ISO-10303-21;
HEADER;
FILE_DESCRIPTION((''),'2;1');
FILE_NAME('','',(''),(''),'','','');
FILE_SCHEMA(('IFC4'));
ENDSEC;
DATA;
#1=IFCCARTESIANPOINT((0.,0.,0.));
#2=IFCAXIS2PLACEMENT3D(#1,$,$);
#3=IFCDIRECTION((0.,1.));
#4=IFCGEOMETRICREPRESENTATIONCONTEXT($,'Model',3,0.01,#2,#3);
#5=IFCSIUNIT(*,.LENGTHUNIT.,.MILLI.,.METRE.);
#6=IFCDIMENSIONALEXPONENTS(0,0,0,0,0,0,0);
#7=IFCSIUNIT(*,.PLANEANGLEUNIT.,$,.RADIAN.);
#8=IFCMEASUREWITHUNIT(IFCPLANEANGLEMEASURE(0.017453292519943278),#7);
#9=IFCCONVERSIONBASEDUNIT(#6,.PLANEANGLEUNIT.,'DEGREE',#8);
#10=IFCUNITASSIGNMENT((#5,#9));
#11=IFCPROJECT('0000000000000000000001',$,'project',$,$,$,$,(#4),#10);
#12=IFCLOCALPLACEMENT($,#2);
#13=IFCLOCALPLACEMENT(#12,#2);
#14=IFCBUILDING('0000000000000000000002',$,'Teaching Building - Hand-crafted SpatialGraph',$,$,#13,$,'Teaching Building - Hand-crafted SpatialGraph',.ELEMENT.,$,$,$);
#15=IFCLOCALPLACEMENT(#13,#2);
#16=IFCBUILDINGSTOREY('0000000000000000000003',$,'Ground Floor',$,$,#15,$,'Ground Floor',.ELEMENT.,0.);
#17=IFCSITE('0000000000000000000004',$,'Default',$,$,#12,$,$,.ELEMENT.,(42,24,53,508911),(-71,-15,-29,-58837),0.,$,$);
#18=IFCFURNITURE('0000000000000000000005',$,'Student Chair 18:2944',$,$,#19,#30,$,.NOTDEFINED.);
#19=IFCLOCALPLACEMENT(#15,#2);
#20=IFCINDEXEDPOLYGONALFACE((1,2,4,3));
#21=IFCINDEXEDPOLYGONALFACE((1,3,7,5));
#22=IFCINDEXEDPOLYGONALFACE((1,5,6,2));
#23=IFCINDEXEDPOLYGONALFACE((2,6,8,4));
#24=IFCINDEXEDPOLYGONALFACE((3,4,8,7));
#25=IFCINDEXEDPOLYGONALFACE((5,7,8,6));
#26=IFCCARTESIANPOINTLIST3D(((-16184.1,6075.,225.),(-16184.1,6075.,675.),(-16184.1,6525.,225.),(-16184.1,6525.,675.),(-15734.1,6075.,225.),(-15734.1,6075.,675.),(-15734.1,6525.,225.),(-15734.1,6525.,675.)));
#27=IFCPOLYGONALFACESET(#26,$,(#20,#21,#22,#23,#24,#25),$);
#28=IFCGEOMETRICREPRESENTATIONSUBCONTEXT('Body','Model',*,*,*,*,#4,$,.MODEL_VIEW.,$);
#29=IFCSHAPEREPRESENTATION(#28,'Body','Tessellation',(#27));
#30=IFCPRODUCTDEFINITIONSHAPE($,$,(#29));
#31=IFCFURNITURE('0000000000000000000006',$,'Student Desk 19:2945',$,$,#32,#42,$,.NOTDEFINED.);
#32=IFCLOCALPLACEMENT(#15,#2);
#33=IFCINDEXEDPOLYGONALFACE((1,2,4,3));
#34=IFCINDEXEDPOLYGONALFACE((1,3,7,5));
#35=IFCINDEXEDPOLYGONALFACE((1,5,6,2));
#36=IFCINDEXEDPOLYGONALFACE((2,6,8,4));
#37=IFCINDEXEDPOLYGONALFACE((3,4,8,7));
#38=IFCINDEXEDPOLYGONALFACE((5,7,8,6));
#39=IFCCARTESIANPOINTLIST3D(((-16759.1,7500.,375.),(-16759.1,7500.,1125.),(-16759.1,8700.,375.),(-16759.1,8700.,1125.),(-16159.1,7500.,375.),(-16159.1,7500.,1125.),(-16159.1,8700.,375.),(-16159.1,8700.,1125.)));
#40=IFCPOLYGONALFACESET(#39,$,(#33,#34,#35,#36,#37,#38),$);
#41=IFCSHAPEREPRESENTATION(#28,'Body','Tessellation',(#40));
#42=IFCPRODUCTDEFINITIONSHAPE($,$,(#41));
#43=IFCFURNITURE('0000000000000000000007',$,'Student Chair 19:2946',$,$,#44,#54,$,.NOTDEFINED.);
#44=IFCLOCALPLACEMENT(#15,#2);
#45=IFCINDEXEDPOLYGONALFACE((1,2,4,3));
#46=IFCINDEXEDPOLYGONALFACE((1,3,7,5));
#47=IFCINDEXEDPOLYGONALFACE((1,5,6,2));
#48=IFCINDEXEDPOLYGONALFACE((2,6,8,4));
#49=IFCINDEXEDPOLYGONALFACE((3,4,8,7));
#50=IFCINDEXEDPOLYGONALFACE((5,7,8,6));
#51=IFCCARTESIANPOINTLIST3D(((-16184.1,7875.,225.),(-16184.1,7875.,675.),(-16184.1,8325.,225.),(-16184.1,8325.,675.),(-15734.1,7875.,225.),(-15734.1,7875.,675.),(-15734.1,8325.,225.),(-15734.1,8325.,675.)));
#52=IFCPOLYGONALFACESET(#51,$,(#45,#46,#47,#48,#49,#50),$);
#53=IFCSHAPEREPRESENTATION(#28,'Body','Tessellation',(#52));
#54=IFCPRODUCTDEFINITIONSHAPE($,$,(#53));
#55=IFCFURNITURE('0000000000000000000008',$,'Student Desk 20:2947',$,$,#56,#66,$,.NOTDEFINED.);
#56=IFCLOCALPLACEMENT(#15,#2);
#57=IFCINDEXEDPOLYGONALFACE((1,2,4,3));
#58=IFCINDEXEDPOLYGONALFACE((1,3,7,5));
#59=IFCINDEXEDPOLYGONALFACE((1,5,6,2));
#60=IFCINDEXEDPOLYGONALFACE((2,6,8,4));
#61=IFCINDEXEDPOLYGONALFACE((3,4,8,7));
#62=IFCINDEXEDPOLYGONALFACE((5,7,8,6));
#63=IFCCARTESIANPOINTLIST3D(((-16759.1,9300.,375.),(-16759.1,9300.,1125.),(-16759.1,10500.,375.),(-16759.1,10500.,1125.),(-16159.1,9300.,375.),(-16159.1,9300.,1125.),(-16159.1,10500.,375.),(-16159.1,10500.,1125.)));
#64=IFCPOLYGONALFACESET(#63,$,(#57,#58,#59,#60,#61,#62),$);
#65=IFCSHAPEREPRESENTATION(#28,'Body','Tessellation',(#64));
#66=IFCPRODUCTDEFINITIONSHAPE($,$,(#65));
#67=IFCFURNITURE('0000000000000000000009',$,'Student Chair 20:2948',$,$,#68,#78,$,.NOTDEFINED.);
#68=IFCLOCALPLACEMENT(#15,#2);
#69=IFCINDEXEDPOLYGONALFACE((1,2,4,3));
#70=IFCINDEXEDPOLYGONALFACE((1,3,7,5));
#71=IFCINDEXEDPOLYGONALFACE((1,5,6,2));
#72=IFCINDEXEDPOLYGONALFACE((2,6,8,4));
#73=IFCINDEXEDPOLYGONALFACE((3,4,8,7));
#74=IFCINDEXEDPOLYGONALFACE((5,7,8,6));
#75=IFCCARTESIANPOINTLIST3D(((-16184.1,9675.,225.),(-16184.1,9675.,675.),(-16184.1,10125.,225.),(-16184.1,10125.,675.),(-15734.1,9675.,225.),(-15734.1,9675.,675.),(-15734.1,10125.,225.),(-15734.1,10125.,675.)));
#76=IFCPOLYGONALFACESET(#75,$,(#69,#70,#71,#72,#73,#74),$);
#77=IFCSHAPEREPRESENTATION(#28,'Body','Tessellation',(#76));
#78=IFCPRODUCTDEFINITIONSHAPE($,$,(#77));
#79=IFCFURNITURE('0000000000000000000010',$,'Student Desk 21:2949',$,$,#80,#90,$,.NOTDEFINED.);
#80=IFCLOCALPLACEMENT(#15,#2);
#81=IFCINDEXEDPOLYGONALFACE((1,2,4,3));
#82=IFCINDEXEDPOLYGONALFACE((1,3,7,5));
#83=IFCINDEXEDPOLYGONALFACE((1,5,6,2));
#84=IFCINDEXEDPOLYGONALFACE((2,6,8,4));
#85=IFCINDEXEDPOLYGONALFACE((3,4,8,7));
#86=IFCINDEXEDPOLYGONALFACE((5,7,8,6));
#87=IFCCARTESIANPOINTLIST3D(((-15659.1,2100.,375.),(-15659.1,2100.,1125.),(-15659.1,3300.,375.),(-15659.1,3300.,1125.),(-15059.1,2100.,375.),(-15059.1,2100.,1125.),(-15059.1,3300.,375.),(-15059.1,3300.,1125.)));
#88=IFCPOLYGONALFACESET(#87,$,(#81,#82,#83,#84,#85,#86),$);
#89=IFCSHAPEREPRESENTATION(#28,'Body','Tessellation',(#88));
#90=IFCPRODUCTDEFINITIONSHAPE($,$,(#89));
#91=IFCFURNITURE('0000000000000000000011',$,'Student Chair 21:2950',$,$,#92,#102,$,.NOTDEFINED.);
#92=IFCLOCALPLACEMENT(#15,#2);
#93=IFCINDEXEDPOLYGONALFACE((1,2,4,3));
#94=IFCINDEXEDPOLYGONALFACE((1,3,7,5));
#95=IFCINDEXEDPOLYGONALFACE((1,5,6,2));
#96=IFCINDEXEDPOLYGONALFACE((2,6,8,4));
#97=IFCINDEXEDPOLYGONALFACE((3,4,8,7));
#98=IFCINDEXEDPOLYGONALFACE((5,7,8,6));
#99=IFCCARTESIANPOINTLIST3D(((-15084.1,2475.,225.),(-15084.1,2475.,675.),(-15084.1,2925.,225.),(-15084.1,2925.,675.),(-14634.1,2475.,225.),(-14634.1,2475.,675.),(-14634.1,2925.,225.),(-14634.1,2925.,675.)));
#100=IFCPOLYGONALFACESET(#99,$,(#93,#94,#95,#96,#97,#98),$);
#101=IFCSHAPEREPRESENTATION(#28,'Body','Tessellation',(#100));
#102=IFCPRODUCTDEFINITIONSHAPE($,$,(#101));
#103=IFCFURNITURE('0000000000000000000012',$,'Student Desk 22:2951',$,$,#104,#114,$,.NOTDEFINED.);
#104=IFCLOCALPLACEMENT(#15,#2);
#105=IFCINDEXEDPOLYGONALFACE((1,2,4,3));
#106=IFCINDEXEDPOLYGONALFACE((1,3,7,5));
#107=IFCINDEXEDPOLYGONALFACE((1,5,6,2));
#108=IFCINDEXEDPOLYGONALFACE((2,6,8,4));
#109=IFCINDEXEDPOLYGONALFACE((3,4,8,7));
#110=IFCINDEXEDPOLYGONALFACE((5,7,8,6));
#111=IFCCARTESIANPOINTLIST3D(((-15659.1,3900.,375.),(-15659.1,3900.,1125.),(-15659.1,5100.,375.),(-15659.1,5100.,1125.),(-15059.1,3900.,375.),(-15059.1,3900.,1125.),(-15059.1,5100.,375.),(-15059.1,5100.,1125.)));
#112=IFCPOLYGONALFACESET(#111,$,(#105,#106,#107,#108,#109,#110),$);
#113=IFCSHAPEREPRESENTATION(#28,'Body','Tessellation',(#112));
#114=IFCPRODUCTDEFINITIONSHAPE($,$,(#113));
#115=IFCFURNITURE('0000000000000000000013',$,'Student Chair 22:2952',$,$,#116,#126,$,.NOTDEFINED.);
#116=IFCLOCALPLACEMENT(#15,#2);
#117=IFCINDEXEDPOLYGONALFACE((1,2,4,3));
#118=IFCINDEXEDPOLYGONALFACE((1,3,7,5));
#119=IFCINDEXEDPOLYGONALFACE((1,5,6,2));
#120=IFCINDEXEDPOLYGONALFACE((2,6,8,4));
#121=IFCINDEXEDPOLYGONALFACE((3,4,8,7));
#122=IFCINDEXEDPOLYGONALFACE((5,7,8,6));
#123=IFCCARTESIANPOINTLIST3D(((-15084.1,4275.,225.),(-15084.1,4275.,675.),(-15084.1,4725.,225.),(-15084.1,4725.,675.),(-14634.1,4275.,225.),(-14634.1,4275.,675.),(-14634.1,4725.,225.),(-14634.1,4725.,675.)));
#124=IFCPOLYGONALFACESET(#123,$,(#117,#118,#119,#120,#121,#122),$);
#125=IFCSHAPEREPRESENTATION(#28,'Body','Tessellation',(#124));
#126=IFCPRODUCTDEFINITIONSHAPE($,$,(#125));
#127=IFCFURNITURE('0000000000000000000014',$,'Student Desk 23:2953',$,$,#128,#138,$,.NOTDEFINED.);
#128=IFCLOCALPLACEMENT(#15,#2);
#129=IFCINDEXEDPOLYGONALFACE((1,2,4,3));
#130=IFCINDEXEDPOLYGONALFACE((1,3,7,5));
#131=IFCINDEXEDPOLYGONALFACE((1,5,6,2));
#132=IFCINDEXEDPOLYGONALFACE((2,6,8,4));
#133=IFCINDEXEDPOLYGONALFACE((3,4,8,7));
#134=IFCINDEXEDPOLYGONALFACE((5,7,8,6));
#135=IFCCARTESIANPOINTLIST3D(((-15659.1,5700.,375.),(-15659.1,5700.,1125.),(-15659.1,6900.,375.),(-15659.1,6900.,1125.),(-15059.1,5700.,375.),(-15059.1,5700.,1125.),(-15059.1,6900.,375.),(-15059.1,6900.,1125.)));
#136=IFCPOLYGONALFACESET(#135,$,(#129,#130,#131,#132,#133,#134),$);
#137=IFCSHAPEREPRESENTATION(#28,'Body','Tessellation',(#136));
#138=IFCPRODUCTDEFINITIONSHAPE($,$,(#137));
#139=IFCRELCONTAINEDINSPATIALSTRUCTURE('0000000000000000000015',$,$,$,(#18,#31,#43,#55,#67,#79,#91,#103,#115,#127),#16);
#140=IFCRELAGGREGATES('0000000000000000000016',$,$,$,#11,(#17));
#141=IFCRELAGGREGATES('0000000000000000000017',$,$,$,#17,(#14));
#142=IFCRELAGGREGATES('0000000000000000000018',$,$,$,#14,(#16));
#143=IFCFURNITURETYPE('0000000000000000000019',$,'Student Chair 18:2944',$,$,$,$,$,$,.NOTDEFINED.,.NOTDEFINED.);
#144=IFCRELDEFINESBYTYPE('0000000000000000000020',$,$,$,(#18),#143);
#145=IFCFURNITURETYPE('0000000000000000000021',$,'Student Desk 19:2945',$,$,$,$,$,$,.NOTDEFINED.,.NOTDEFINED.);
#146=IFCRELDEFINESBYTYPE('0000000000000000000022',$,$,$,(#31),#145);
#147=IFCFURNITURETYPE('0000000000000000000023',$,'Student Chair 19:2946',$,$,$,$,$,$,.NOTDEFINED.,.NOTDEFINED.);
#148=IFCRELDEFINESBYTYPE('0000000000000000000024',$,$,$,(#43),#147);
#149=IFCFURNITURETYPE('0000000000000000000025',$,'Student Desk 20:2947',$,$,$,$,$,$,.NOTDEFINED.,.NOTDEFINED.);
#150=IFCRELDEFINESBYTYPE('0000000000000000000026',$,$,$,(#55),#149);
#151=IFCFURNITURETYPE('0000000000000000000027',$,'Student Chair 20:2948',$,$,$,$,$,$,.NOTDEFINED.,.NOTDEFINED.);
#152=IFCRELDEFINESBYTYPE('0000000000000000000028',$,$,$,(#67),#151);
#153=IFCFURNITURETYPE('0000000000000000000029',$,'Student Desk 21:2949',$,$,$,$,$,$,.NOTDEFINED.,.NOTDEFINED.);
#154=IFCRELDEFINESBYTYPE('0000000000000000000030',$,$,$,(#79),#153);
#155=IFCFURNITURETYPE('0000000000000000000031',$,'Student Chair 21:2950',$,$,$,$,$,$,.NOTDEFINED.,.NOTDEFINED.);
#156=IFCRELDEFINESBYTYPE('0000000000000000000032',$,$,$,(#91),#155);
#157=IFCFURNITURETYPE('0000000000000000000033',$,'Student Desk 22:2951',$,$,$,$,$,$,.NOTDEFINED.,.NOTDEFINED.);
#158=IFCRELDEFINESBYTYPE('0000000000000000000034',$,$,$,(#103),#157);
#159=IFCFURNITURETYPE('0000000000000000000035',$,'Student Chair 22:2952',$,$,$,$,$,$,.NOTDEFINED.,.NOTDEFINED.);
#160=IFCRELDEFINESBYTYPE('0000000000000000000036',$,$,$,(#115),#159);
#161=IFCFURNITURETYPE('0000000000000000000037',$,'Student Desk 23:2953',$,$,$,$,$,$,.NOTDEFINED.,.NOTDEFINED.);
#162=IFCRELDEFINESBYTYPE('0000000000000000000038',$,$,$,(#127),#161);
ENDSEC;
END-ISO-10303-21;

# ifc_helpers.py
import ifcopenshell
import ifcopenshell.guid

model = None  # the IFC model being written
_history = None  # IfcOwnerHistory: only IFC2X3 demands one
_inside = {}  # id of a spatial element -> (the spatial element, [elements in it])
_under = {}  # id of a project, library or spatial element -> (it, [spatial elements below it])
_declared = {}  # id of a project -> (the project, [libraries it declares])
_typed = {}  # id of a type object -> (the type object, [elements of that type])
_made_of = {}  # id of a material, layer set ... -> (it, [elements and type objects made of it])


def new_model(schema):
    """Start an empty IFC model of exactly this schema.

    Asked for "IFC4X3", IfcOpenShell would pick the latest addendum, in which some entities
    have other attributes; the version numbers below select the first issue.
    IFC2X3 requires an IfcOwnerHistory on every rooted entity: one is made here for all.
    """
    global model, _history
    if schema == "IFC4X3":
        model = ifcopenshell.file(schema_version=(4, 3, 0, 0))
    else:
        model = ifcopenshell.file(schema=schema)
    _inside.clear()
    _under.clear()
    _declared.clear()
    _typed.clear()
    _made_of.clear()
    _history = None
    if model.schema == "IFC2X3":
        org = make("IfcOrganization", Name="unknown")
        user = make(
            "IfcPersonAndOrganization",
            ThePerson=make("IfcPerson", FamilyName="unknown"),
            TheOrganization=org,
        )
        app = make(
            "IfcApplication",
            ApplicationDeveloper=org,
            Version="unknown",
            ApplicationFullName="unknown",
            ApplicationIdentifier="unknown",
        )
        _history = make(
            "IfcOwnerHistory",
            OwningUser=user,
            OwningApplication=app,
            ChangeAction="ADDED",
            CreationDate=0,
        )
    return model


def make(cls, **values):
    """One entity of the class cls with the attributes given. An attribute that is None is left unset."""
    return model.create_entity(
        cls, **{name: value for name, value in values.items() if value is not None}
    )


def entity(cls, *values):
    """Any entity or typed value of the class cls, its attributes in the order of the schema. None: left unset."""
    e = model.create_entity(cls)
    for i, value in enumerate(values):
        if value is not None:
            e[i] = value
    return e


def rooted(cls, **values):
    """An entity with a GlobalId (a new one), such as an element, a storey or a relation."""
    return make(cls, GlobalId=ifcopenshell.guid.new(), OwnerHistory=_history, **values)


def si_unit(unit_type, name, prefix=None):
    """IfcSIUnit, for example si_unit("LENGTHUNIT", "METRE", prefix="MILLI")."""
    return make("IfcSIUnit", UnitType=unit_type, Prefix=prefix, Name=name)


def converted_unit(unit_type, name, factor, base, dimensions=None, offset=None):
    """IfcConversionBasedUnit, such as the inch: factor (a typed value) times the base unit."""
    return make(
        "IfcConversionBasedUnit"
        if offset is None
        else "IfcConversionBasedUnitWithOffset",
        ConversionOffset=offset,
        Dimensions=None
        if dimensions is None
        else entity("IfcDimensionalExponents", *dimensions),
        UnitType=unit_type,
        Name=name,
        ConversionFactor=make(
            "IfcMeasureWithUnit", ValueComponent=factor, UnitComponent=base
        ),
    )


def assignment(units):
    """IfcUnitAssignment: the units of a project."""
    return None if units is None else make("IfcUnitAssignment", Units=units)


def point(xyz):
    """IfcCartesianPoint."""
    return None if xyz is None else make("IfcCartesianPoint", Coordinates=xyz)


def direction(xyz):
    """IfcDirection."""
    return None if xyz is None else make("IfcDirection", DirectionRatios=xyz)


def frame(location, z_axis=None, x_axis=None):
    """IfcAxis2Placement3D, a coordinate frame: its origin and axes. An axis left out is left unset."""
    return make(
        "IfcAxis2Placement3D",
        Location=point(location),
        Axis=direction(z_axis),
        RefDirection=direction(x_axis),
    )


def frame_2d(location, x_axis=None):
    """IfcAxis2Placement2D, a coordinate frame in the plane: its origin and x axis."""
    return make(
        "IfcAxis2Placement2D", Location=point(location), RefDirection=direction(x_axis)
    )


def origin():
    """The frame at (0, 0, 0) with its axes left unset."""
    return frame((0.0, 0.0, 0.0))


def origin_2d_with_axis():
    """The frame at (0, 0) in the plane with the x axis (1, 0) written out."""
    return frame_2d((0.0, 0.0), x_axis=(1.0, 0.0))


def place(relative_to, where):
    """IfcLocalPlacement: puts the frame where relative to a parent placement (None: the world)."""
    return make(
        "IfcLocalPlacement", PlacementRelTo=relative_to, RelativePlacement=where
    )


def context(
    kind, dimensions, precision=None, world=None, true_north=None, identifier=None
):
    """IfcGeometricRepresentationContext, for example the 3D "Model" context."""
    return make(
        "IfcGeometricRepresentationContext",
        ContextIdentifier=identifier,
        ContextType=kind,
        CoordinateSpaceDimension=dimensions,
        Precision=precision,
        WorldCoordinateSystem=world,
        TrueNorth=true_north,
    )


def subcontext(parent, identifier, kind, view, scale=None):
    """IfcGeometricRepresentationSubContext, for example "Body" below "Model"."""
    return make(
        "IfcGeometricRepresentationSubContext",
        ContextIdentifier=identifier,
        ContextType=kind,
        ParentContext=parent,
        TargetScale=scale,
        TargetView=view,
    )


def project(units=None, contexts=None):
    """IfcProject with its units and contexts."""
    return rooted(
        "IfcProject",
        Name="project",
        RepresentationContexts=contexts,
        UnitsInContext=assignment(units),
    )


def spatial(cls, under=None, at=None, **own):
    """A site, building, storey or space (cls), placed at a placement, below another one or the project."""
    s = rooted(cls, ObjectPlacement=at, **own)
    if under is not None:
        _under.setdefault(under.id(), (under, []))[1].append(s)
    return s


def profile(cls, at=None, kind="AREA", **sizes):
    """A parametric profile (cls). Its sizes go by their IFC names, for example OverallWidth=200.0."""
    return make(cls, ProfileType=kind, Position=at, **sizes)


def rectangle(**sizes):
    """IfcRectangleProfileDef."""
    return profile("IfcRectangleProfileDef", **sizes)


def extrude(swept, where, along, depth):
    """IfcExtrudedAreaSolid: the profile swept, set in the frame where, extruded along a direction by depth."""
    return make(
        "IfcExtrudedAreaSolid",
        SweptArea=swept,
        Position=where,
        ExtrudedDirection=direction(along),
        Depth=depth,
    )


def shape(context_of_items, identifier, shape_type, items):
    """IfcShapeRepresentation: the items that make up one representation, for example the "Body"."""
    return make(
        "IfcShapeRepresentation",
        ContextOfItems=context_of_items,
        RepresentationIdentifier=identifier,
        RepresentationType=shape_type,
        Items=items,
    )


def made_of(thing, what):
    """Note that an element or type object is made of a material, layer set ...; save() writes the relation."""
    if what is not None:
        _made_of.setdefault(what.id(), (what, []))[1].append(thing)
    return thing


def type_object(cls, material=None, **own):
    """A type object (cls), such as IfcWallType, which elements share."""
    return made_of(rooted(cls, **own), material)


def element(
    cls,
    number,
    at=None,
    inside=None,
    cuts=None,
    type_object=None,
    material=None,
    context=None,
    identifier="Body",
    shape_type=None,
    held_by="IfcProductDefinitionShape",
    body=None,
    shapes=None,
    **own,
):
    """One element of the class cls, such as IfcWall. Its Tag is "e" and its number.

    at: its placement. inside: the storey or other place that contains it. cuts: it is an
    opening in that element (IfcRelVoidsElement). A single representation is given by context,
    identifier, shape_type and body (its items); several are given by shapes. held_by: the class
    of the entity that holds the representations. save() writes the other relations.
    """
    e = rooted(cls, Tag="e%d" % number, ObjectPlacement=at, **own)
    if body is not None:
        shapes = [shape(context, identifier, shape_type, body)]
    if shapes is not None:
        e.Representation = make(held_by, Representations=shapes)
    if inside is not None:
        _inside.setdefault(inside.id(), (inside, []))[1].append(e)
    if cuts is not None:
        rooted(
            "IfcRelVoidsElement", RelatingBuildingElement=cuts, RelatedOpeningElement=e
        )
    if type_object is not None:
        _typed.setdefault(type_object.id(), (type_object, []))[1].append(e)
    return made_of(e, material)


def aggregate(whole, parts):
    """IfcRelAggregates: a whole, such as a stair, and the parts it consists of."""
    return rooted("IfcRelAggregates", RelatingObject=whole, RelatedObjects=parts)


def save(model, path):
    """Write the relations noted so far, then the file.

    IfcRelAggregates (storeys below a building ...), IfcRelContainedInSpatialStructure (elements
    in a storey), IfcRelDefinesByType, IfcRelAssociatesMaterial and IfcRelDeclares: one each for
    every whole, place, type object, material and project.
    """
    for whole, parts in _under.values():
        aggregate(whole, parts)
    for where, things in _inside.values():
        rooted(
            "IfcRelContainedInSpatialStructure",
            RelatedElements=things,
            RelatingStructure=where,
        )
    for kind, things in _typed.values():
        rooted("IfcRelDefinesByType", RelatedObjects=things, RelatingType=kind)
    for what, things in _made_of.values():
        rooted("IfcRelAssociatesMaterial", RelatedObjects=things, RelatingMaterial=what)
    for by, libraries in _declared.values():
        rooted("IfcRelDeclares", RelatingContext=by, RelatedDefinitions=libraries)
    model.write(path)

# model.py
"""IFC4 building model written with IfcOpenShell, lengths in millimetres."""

from ifc_helpers import new_model, entity, si_unit, converted_unit, direction, frame, frame_2d, origin, origin_2d_with_axis, place, context, subcontext, project, spatial, rectangle, extrude, type_object, element, save


model = new_model("IFC4")

# Units and contexts
model_context = context("Model", 3, precision=0.01, world=origin(), true_north=direction((0.0, 1.0)))
body_context = subcontext(model_context, "Body", "Model", "MODEL_VIEW")
ifc_project = project(units=[si_unit("LENGTHUNIT", "METRE", prefix="MILLI"), converted_unit("PLANEANGLEUNIT", "DEGREE", entity("IfcPlaneAngleMeasure", 0.017453292519943278), si_unit("PLANEANGLEUNIT", "RADIAN"), dimensions=[0, 0, 0, 0, 0, 0, 0])], contexts=[model_context])

# Site, building, storey
site_placement = place(None, origin())
site = spatial("IfcSite", under=ifc_project, at=site_placement, Name="Default", CompositionType="ELEMENT", RefLatitude=(42, 24, 53, 508911), RefLongitude=(-71, -15, -29, -58837), RefElevation=0.0)
building_placement = place(site_placement, origin())
building = spatial("IfcBuilding", under=site, at=building_placement, Name="Teaching Building - Hand-crafted SpatialGraph", LongName="Teaching Building - Hand-crafted SpatialGraph", CompositionType="ELEMENT")
storey_placement = place(building_placement, origin())
storey = spatial("IfcBuildingStorey", under=building, at=storey_placement, Name="Ground Floor", LongName="Ground Floor", CompositionType="ELEMENT", Elevation=0.0)

# Furniture
furniture_type_1 = type_object("IfcFurnitureType", Name="Student Chair 18:2944", PredefinedType="NOTDEFINED")
furniture_1_placement = place(storey_placement, origin())
element("IfcFurniture", 1, at=furniture_1_placement, inside=storey, type_object=furniture_type_1, Name="Student Chair 18:2944", PredefinedType="NOTDEFINED", context=body_context, shape_type="SweptSolid", body=[
    extrude(rectangle(XDim=450.0, YDim=450.0, at=origin_2d_with_axis()), frame((-15959.1, 6300.0, 225.0)), (0.0, 0.0, 1.0), 450.0),
])
furniture_type_2 = type_object("IfcFurnitureType", Name="Student Desk 19:2945", PredefinedType="NOTDEFINED")
furniture_2_placement = place(storey_placement, origin())
element("IfcFurniture", 2, at=furniture_2_placement, inside=storey, type_object=furniture_type_2, Name="Student Desk 19:2945", PredefinedType="NOTDEFINED", context=body_context, shape_type="SweptSolid", body=[
    extrude(rectangle(XDim=1200.0, YDim=600.0, at=origin_2d_with_axis()), frame((-16459.1, 8100.0, 375.0), z_axis=(0.0, 0.0, 1.0), x_axis=(0.0, 1.0, 0.0)), (0.0, 0.0, 1.0), 750.0),
])
furniture_type_3 = type_object("IfcFurnitureType", Name="Student Chair 19:2946", PredefinedType="NOTDEFINED")
furniture_3_placement = place(storey_placement, origin())
element("IfcFurniture", 3, at=furniture_3_placement, inside=storey, type_object=furniture_type_3, Name="Student Chair 19:2946", PredefinedType="NOTDEFINED", context=body_context, shape_type="SweptSolid", body=[
    extrude(rectangle(XDim=450.0, YDim=450.0, at=origin_2d_with_axis()), frame((-15959.1, 8100.0, 225.0)), (0.0, 0.0, 1.0), 450.0),
])
furniture_type_4 = type_object("IfcFurnitureType", Name="Student Desk 20:2947", PredefinedType="NOTDEFINED")
furniture_4_placement = place(storey_placement, origin())
element("IfcFurniture", 4, at=furniture_4_placement, inside=storey, type_object=furniture_type_4, Name="Student Desk 20:2947", PredefinedType="NOTDEFINED", context=body_context, shape_type="SweptSolid", body=[
    extrude(rectangle(XDim=1200.0, YDim=600.0, at=origin_2d_with_axis()), frame((-16459.1, 9900.0, 375.0), z_axis=(0.0, 0.0, 1.0), x_axis=(0.0, 1.0, 0.0)), (0.0, 0.0, 1.0), 750.0),
])
furniture_type_5 = type_object("IfcFurnitureType", Name="Student Chair 20:2948", PredefinedType="NOTDEFINED")
furniture_5_placement = place(storey_placement, origin())
element("IfcFurniture", 5, at=furniture_5_placement, inside=storey, type_object=furniture_type_5, Name="Student Chair 20:2948", PredefinedType="NOTDEFINED", context=body_context, shape_type="SweptSolid", body=[
    extrude(rectangle(XDim=450.0, YDim=450.0, at=frame_2d((0.0, 0.0), x_axis=(1.0, 0.0))), frame((-15959.1, 9900.0, 225.0)), (0.0, 0.0, 1.0), 450.0),
])
furniture_type_6 = type_object("IfcFurnitureType", Name="Student Desk 21:2949", PredefinedType="NOTDEFINED")
furniture_6_placement = place(storey_placement, origin())
element("IfcFurniture", 6, at=furniture_6_placement, inside=storey, type_object=furniture_type_6, Name="Student Desk 21:2949", PredefinedType="NOTDEFINED", context=body_context, shape_type="SweptSolid", body=[
    extrude(rectangle(XDim=1200.0, YDim=600.0, at=origin_2d_with_axis()), frame((-15359.1, 2700.0, 375.0), z_axis=(0.0, 0.0, 1.0), x_axis=(0.0, 1.0, 0.0)), (0.0, 0.0, 1.0), 750.0),
])
furniture_type_7 = type_object("IfcFurnitureType", Name="Student Chair 21:2950", PredefinedType="NOTDEFINED")
furniture_7_placement = place(storey_placement, origin())
element("IfcFurniture", 7, at=furniture_7_placement, inside=storey, type_object=furniture_type_7, Name="Student Chair 21:2950", PredefinedType="NOTDEFINED", context=body_context, shape_type="SweptSolid", body=[
    extrude(rectangle(XDim=450.0, YDim=450.0, at=origin_2d_with_axis()), frame((-14859.1, 2700.0, 225.0)), (0.0, 0.0, 1.0), 450.0),
])
furniture_type_8 = type_object("IfcFurnitureType", Name="Student Desk 22:2951", PredefinedType="NOTDEFINED")
furniture_8_placement = place(storey_placement, origin())
element("IfcFurniture", 8, at=furniture_8_placement, inside=storey, type_object=furniture_type_8, Name="Student Desk 22:2951", PredefinedType="NOTDEFINED", context=body_context, shape_type="SweptSolid", body=[
    extrude(rectangle(XDim=1200.0, YDim=600.0, at=frame_2d((0.0, 0.0), x_axis=(1.0, 0.0))), frame((-15359.1, 4500.0, 375.0), z_axis=(0.0, 0.0, 1.0), x_axis=(0.0, 1.0, 0.0)), (0.0, 0.0, 1.0), 750.0),
])
furniture_type_9 = type_object("IfcFurnitureType", Name="Student Chair 22:2952", PredefinedType="NOTDEFINED")
furniture_9_placement = place(storey_placement, origin())
element("IfcFurniture", 9, at=furniture_9_placement, inside=storey, type_object=furniture_type_9, Name="Student Chair 22:2952", PredefinedType="NOTDEFINED", context=body_context, shape_type="SweptSolid", body=[
    extrude(rectangle(XDim=450.0, YDim=450.0, at=origin_2d_with_axis()), frame((-14859.1, 4500.0, 225.0)), (0.0, 0.0, 1.0), 450.0),
])
furniture_type_10 = type_object("IfcFurnitureType", Name="Student Desk 23:2953", PredefinedType="NOTDEFINED")
furniture_10_placement = place(storey_placement, origin())
element("IfcFurniture", 10, at=furniture_10_placement, inside=storey, type_object=furniture_type_10, Name="Student Desk 23:2953", PredefinedType="NOTDEFINED", context=body_context, shape_type="SweptSolid", body=[
    extrude(rectangle(XDim=1200.0, YDim=600.0, at=origin_2d_with_axis()), frame((-15359.1, 6300.0, 375.0), z_axis=(0.0, 0.0, 1.0), x_axis=(0.0, 1.0, 0.0)), (0.0, 0.0, 1.0), 750.0),
])

save(model, "model.ifc")
